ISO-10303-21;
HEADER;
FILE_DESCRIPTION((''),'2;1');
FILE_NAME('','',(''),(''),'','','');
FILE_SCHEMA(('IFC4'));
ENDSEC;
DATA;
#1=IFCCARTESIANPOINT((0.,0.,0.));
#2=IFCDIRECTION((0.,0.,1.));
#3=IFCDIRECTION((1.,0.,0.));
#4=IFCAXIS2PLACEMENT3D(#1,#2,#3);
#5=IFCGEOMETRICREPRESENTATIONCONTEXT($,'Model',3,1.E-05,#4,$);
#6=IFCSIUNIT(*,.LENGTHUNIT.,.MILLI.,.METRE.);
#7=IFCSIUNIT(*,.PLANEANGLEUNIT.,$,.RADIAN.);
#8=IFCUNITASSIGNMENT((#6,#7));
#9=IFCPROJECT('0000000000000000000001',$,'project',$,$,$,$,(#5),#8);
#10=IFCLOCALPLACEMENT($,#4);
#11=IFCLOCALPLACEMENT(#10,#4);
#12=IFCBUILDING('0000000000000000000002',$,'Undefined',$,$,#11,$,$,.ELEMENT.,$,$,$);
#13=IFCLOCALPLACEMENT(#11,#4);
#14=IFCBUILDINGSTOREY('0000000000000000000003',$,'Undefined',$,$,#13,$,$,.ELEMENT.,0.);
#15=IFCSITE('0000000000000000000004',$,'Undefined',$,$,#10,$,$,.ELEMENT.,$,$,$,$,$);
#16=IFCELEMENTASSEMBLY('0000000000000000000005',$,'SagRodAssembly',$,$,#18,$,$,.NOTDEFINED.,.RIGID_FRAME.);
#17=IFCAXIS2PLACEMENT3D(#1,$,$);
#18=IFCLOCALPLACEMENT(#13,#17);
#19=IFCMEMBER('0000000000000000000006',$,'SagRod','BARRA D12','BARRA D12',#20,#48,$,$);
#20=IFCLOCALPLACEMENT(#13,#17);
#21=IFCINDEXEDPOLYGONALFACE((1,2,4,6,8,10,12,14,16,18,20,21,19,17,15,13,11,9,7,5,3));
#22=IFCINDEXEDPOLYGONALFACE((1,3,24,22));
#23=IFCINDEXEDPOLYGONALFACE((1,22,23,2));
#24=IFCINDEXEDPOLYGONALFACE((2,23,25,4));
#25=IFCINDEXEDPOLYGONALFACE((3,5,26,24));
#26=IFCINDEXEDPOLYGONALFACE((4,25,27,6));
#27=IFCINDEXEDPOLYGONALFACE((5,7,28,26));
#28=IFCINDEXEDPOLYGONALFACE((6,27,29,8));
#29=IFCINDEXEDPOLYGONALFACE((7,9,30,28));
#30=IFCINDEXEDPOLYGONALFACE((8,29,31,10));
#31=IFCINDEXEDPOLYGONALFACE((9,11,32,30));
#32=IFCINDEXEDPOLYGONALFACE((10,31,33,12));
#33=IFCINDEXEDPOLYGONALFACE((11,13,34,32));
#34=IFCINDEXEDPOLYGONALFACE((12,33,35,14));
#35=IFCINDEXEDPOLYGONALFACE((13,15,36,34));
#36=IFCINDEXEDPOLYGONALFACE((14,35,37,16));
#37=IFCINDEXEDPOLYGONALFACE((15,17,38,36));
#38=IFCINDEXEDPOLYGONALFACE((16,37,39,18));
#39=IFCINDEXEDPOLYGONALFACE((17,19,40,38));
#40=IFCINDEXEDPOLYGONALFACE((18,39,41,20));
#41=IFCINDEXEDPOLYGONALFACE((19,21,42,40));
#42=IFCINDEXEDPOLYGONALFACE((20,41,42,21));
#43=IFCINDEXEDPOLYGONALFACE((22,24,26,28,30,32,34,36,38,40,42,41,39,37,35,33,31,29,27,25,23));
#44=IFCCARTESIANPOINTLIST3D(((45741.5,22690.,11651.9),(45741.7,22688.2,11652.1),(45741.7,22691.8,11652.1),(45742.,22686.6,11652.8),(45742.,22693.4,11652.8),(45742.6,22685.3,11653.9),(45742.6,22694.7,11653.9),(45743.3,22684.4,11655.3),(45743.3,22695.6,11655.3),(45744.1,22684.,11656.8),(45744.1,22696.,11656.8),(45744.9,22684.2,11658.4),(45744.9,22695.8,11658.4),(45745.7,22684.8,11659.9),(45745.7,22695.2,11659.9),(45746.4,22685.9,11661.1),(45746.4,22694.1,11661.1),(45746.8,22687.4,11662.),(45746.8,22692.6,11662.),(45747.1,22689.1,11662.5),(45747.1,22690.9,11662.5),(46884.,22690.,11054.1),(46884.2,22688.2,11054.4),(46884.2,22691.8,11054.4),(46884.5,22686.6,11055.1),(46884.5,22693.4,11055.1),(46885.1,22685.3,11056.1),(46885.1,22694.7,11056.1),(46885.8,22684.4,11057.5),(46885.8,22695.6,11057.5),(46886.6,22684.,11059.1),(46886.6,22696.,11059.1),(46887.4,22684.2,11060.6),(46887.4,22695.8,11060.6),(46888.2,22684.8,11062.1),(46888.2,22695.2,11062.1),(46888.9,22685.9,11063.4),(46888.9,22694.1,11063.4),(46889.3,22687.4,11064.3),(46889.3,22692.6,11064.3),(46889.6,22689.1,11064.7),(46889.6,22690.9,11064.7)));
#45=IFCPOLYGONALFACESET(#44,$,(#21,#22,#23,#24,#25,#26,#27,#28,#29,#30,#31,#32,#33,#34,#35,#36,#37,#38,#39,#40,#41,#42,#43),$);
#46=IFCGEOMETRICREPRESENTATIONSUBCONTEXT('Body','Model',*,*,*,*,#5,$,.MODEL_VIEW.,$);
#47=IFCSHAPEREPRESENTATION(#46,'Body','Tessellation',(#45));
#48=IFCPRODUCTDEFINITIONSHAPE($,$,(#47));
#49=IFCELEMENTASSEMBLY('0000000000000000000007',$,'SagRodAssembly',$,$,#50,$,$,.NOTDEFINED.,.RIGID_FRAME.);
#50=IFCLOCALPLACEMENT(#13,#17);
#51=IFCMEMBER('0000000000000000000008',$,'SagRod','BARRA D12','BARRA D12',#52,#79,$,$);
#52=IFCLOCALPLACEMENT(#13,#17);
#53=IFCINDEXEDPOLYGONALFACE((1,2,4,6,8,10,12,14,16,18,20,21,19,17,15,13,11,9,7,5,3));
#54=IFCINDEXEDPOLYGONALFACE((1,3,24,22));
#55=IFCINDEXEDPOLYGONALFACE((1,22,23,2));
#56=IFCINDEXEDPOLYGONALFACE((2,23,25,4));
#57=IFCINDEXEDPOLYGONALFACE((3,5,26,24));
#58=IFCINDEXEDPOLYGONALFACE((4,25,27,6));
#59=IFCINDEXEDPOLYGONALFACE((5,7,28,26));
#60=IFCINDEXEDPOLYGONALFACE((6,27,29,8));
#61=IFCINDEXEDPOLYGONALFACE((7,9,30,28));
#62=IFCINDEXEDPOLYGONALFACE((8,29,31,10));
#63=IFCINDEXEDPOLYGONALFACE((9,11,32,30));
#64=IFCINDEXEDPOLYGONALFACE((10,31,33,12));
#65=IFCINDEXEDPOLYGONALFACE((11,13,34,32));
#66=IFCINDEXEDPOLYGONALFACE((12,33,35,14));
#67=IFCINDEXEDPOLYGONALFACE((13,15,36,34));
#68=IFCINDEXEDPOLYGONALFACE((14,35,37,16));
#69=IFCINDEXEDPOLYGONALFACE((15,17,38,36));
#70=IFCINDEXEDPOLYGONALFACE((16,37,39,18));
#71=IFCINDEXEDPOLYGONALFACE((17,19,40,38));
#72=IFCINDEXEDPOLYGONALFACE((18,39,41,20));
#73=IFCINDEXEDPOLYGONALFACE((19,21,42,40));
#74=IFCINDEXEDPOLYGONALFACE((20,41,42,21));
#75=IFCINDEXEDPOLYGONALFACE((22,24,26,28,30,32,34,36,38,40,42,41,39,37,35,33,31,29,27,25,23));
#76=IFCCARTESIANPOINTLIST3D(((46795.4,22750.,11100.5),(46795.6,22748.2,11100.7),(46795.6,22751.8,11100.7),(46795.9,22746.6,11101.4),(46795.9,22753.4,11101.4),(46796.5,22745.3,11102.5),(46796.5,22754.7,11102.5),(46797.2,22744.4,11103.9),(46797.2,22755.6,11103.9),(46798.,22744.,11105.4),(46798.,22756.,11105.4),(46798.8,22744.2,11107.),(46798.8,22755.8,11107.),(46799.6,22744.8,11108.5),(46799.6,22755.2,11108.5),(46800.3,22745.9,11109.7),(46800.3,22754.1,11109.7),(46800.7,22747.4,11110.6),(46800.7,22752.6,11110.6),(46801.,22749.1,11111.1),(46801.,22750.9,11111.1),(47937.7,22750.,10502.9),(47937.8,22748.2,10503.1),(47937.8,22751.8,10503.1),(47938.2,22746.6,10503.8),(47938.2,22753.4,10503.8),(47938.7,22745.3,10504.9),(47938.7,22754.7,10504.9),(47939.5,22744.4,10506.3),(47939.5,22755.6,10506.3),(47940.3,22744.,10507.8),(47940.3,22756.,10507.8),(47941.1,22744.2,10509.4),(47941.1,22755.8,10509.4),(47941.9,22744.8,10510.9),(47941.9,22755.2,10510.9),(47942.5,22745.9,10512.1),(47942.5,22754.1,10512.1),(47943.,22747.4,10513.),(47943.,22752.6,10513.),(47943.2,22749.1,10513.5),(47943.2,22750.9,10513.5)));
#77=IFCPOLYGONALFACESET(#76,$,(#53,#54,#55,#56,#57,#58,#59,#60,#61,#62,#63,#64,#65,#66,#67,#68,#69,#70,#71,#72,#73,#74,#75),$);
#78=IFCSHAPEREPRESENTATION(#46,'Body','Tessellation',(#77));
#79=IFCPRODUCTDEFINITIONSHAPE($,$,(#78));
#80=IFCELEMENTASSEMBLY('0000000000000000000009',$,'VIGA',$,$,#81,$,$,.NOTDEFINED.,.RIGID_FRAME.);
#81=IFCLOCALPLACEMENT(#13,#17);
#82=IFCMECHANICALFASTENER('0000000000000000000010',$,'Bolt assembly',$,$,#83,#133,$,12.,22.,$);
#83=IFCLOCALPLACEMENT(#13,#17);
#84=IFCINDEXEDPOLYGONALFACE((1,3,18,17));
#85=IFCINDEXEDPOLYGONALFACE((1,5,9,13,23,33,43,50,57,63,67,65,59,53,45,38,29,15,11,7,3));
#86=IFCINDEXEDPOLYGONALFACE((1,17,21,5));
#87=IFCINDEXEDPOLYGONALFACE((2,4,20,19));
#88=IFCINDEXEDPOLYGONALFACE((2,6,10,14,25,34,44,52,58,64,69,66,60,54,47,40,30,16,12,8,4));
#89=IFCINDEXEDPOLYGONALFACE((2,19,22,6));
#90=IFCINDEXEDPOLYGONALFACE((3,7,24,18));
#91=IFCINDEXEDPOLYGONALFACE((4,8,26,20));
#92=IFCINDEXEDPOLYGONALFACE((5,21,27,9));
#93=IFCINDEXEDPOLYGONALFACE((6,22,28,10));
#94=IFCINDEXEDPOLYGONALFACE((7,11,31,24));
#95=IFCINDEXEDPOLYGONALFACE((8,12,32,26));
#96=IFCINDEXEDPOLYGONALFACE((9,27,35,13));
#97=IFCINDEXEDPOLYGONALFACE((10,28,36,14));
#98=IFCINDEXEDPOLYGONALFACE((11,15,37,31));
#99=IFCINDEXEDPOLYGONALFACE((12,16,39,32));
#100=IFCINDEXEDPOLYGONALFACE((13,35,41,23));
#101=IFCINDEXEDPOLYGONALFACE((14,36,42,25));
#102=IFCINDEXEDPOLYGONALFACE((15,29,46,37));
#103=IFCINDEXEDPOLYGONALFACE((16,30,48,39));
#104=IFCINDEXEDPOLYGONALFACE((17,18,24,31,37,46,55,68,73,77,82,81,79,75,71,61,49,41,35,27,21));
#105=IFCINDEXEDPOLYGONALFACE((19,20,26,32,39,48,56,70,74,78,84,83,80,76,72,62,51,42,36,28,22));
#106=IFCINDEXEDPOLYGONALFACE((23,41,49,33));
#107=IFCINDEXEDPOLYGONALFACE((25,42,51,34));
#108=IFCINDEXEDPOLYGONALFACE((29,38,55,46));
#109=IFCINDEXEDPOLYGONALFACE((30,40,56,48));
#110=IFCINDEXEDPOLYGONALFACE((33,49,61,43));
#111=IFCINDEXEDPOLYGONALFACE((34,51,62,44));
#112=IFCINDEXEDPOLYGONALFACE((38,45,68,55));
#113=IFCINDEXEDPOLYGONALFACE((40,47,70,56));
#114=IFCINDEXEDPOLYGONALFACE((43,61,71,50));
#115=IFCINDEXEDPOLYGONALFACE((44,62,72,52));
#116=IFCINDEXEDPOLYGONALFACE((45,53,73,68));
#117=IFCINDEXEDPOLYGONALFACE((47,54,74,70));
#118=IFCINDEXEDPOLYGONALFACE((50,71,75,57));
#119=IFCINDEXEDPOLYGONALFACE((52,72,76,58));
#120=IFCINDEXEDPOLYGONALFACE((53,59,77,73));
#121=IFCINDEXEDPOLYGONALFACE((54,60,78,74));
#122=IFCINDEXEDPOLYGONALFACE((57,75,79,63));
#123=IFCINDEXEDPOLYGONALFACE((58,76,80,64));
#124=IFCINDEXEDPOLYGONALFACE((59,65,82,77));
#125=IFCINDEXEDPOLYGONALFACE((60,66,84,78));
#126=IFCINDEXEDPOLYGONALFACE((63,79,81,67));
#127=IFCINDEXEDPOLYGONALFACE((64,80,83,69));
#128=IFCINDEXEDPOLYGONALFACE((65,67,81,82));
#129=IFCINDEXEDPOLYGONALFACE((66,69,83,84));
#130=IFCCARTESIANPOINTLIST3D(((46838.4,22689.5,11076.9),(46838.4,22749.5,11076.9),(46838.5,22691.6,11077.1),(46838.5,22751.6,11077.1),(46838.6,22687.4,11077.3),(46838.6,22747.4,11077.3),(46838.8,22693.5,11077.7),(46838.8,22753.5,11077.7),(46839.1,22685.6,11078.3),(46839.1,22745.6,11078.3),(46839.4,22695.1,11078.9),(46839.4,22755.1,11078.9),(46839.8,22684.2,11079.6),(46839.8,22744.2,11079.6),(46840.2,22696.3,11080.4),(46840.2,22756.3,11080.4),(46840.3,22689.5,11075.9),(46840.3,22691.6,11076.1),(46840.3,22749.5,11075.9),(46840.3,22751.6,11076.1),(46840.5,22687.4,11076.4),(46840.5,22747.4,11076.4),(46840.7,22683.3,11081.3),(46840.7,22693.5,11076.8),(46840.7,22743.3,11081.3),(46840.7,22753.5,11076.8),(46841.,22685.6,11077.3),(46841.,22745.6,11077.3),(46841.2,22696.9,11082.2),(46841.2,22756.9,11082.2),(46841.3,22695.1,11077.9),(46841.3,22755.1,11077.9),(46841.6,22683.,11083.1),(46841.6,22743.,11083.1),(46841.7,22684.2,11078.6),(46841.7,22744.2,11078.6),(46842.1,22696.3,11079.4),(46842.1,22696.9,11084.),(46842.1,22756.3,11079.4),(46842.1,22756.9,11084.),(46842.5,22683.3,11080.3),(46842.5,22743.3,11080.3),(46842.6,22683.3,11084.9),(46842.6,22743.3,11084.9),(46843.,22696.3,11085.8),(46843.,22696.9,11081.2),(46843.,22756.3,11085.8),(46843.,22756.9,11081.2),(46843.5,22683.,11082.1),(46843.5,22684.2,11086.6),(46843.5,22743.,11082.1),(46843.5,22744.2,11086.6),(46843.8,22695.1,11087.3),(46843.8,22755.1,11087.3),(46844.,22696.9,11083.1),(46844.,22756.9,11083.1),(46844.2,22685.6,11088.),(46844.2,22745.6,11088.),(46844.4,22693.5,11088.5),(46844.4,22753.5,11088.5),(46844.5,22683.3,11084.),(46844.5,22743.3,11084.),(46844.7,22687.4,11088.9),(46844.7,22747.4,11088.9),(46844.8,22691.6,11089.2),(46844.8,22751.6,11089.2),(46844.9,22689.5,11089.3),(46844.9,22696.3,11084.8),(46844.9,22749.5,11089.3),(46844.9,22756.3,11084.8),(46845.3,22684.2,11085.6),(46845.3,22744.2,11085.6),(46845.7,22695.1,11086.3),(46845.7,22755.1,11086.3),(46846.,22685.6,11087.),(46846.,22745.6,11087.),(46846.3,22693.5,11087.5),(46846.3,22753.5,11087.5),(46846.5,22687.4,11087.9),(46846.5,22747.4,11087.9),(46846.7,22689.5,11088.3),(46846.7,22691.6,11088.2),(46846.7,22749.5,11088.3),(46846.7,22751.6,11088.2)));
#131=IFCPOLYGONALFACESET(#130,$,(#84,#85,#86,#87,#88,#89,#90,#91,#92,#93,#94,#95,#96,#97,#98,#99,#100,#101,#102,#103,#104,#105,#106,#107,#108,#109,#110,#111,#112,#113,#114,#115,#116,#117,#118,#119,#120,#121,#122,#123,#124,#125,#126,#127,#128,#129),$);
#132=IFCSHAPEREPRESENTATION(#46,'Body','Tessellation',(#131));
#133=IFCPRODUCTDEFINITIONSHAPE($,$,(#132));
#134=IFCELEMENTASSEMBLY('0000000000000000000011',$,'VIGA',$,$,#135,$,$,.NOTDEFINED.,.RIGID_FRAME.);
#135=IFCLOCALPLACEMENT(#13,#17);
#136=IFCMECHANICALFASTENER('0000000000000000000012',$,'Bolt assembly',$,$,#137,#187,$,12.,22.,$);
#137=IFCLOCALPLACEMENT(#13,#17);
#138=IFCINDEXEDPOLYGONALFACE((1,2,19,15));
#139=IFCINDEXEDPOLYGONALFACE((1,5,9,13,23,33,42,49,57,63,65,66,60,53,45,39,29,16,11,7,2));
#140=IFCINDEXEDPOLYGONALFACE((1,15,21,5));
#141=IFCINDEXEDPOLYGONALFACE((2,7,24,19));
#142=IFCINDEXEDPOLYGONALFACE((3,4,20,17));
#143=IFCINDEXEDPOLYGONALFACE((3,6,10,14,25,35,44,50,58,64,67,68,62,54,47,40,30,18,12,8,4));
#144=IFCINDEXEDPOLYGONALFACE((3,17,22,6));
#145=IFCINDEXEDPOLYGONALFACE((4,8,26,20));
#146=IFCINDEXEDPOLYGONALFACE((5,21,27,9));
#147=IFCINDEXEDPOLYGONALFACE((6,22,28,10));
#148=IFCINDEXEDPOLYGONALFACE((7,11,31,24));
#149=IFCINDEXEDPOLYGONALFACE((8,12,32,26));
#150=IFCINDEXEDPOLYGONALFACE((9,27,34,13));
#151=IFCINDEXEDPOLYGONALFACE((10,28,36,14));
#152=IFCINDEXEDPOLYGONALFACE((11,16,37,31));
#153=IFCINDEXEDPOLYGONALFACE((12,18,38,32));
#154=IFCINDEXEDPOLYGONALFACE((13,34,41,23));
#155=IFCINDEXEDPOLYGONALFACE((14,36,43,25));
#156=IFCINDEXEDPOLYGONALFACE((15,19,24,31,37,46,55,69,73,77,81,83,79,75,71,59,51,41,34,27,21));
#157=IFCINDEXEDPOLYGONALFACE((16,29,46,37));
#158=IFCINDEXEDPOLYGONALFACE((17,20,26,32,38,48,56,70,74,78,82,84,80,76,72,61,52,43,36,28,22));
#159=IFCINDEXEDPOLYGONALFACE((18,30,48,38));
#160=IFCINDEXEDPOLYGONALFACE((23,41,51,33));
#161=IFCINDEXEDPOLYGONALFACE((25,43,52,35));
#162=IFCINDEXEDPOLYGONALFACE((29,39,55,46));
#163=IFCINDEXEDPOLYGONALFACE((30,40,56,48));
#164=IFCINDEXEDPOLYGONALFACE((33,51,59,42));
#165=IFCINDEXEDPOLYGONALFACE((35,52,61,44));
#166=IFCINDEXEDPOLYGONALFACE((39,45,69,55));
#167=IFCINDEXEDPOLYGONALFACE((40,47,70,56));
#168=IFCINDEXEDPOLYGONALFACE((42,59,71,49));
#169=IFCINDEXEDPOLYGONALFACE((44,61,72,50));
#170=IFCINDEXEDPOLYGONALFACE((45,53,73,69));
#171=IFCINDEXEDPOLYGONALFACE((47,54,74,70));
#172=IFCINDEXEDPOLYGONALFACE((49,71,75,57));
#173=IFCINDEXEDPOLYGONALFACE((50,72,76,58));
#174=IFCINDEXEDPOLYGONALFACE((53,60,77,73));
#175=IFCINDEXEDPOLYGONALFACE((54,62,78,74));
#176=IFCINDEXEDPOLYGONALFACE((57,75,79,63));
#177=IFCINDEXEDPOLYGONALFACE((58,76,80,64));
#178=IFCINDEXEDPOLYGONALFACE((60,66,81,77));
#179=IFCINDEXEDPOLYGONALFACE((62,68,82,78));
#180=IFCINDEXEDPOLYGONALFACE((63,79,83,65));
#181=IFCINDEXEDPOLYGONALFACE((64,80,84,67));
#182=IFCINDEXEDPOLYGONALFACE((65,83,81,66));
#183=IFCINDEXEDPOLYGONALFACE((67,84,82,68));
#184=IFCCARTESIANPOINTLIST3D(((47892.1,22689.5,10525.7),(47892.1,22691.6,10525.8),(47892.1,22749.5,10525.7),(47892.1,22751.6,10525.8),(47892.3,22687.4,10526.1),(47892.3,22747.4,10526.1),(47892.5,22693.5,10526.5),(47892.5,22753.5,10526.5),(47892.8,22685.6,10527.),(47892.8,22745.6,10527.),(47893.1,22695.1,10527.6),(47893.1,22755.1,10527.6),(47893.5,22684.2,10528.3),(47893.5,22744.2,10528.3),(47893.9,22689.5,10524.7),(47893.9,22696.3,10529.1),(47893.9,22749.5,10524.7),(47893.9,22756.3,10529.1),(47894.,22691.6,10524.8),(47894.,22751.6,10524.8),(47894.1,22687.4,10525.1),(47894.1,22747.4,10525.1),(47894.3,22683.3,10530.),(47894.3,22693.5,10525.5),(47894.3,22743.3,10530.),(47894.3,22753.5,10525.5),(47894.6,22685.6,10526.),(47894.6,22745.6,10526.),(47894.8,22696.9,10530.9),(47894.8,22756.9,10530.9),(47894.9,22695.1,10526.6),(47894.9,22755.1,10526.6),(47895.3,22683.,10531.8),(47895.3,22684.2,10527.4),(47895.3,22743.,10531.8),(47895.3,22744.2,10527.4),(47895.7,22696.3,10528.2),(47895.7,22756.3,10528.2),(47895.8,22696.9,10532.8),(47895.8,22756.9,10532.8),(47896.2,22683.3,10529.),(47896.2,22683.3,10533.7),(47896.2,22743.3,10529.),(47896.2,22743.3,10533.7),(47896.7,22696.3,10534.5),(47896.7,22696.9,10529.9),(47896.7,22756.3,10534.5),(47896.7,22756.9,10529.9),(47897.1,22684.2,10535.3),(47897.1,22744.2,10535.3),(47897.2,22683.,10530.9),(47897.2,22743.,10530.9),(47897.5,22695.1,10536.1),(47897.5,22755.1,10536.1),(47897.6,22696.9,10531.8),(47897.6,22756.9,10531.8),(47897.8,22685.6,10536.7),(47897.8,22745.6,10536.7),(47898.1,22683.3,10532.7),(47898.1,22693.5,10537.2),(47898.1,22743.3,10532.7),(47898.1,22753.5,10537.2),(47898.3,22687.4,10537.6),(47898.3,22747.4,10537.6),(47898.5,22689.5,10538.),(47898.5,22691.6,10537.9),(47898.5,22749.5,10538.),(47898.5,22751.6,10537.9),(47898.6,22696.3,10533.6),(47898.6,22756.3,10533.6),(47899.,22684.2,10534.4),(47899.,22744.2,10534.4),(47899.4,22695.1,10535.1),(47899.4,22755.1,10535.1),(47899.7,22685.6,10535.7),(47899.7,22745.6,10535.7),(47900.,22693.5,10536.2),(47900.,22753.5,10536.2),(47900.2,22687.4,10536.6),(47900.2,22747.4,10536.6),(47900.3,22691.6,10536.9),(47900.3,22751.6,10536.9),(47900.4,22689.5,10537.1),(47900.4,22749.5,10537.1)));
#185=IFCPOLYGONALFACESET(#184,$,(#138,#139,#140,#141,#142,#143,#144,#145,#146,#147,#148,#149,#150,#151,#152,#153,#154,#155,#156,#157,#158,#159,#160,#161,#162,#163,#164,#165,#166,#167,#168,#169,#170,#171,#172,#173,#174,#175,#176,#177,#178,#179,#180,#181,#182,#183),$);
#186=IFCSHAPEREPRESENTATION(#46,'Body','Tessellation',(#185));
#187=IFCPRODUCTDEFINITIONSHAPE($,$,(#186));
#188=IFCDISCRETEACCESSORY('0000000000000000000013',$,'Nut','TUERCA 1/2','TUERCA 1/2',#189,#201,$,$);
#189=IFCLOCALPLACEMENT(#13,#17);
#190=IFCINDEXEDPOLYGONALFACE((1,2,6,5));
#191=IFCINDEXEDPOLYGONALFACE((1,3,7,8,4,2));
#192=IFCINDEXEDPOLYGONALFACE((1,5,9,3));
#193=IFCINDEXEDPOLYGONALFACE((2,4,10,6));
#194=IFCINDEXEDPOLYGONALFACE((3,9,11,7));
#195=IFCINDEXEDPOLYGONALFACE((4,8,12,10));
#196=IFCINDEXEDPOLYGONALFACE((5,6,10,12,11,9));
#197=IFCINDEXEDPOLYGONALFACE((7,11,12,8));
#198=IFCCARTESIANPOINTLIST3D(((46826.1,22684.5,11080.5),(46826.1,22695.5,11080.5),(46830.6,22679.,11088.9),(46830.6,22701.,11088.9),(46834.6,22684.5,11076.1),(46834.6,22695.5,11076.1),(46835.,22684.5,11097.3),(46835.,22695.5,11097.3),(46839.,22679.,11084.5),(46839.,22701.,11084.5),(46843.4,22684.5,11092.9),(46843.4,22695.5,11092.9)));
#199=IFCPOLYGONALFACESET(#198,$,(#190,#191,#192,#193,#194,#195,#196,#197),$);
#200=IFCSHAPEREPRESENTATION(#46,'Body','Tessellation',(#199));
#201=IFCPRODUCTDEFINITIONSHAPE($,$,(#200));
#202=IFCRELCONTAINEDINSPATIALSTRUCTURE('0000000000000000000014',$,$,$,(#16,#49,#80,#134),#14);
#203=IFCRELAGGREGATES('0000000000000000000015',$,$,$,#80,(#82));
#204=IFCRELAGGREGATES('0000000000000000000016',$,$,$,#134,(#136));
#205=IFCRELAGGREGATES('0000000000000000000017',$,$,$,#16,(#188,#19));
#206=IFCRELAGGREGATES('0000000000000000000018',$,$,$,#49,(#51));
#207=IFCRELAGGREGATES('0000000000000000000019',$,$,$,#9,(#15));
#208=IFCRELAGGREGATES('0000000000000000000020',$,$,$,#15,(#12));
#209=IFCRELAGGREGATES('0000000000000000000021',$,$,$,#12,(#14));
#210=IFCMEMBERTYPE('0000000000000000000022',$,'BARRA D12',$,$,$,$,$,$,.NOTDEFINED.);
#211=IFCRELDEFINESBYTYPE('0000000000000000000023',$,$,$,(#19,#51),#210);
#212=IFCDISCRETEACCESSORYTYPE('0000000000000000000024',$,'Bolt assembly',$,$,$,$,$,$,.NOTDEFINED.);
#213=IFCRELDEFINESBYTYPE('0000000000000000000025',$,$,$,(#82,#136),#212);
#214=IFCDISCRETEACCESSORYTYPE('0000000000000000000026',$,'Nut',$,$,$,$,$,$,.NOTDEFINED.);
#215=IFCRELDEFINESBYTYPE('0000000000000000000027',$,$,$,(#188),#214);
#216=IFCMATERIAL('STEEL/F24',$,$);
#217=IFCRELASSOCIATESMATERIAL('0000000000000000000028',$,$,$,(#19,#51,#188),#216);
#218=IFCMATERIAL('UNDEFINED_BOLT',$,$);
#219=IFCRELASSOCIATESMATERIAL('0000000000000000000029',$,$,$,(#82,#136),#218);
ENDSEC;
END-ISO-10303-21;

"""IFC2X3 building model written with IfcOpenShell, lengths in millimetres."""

from ifc_helpers import new_model, si_unit, frame, origin_with_axes, origin_2d_with_axis, place, context, subcontext, project, spatial, polyline, circle, outline, extrude, source, transform, mapped, material, type_object, element, aggregate, save


model = new_model("IFC2X3")

# Units and contexts
model_context = context("Model", 3, precision=1e-05, world=origin_with_axes())
body_context = subcontext(model_context, "Body", "Model", "MODEL_VIEW")
ifc_project = project(units=[si_unit("LENGTHUNIT", "METRE", prefix="MILLI"), si_unit("PLANEANGLEUNIT", "RADIAN")], contexts=[model_context])

# Site, building, storey
site_placement = place(None, origin_with_axes())
site = spatial("IfcSite", under=ifc_project, at=site_placement, Name="Undefined", CompositionType="ELEMENT")
building_placement = place(site_placement, origin_with_axes())
building = spatial("IfcBuilding", under=site, at=building_placement, Name="Undefined", CompositionType="ELEMENT")
storey_placement = place(building_placement, origin_with_axes())
storey = spatial("IfcBuildingStorey", under=building, at=storey_placement, Name="Undefined", CompositionType="ELEMENT", Elevation=0.0)

# Element assemblies, members
assembly_1_placement = place(storey_placement, origin_with_axes())
assembly_1 = element("IfcElementAssembly", 1, at=assembly_1_placement, inside=storey, Name="SagRodAssembly", AssemblyPlace="NOTDEFINED", PredefinedType="RIGID_FRAME")
ifc_material_1 = material(Name="STEEL/F24")
member_type = type_object("IfcMemberType", Name="BARRA D12", PredefinedType="NOTDEFINED")
member_1_placement = place(assembly_1_placement, frame((46886.8, 22690.0, 11059.5), z_axis=(0.0, 1.0, 0.0), x_axis=(-0.886056, 0.0, 0.463578)))
member_1 = element("IfcMember", 2, at=member_1_placement, type_object=member_type, material=ifc_material_1, Name="SagRod", Description="BARRA D12", ObjectType="BARRA D12", context=body_context, shape_type="SweptSolid", body=[
    extrude(circle(Radius=6.0, at=origin_2d_with_axis()), frame((1289.4, 0.0, 0.0), z_axis=(-1.0, 0.0, 0.0), x_axis=(0.0, -1.0, 0.0)), (0.0, 0.0, 1.0), 1289.4),
])
assembly_2_placement = place(storey_placement, origin_with_axes())
assembly_2 = element("IfcElementAssembly", 3, at=assembly_2_placement, inside=storey, Name="SagRodAssembly", AssemblyPlace="NOTDEFINED", PredefinedType="RIGID_FRAME")
member_2_placement = place(assembly_2_placement, frame((47940.5, 22750.0, 10508.2), z_axis=(0.0, 1.0, 0.0), x_axis=(-0.886056, 0.0, 0.463578)))
member_2 = element("IfcMember", 4, at=member_2_placement, type_object=member_type, material=ifc_material_1, Name="SagRod", Description="BARRA D12", ObjectType="BARRA D12", context=body_context, shape_type="SweptSolid", body=[
    extrude(circle(Radius=6.0, at=origin_2d_with_axis()), frame((1289.1, 0.0, 0.0), z_axis=(-1.0, 0.0, 0.0), x_axis=(0.0, -1.0, 0.0)), (0.0, 0.0, 1.0), 1289.2),
])

# Element assemblies, mechanical fasteners
assembly_3_placement = place(storey_placement, origin_with_axes())
assembly_3 = element("IfcElementAssembly", 5, at=assembly_3_placement, inside=storey, Name="VIGA", AssemblyPlace="NOTDEFINED", PredefinedType="RIGID_FRAME")
ifc_material_2 = material(Name="UNDEFINED_BOLT")
discrete_accessory_type_1 = type_object("IfcDiscreteAccessoryType", Name="Bolt assembly")
shared_shape = source(origin_with_axes(), body_context, "Body", "SweptSolid", [
    extrude(circle(Radius=7.0, at=origin_2d_with_axis()), frame((0.0, -1.0, 0.0), z_axis=(0.0, 1.0, 0.0), x_axis=(1.0, 0.0, 0.0)), (0.0, 0.0, 1.0), 2.1),
])
mechanical_fastener_1_placement = place(assembly_3_placement, frame((46842.5, 22750.0, 11082.6), z_axis=(0.463605, 0.0, 0.886042), x_axis=(0.0, -1.0, 0.0)))
mechanical_fastener_1 = element("IfcMechanicalFastener", 6, at=mechanical_fastener_1_placement, type_object=discrete_accessory_type_1, material=ifc_material_2, Name="Bolt assembly", NominalDiameter=12.0, NominalLength=22.0, context=body_context, shape_type="MappedRepresentation", body=[
    mapped(shared_shape, transform((0.0, 0.0, 0.0))),
    mapped(shared_shape, transform((60.0, 0.0, 0.0))),
])
aggregate(assembly_3, [mechanical_fastener_1])
assembly_4_placement = place(storey_placement, origin_with_axes())
assembly_4 = element("IfcElementAssembly", 7, at=assembly_4_placement, inside=storey, Name="VIGA", AssemblyPlace="NOTDEFINED", PredefinedType="RIGID_FRAME")
mechanical_fastener_2_placement = place(assembly_4_placement, frame((47896.2, 22750.0, 10531.4), z_axis=(0.463605, 0.0, 0.886042), x_axis=(0.0, -1.0, 0.0)))
mechanical_fastener_2 = element("IfcMechanicalFastener", 8, at=mechanical_fastener_2_placement, type_object=discrete_accessory_type_1, material=ifc_material_2, Name="Bolt assembly", NominalDiameter=12.0, NominalLength=22.0, context=body_context, shape_type="MappedRepresentation", body=[
    mapped(shared_shape, transform((0.0, 0.0, 0.0))),
    mapped(shared_shape, transform((60.0, 0.0, 0.0))),
])
aggregate(assembly_4, [mechanical_fastener_2])

# Discrete accessory
discrete_accessory_type_2 = type_object("IfcDiscreteAccessoryType", Name="Nut")
discrete_accessory_1_placement = place(assembly_1_placement, frame((46839.0, 22690.0, 11084.5), z_axis=(-0.463578, 0.0, -0.886056), x_axis=(-0.886056, 0.0, 0.463578)))
discrete_accessory_1 = element("IfcDiscreteAccessory", 9, at=discrete_accessory_1_placement, type_object=discrete_accessory_type_2, material=ifc_material_1, Name="Nut", Description="TUERCA 1/2", ObjectType="TUERCA 1/2", context=body_context, shape_type="SweptSolid", body=[
    extrude(outline(polyline([(-5.5, 9.5), (5.5, 9.5), (11.0, 0.0), (5.5, -9.5), (-5.5, -9.5), (-11.0, 0.0), (-5.5, 9.5)])), frame((9.5, 0.0, 0.0), z_axis=(-1.0, 0.0, 0.0), x_axis=(0.0, -1.0, 0.0)), (0.0, 0.0, 1.0), 9.5),
])

aggregate(assembly_1, [discrete_accessory_1, member_1])
aggregate(assembly_2, [member_2])

save(model, "model.ifc")
